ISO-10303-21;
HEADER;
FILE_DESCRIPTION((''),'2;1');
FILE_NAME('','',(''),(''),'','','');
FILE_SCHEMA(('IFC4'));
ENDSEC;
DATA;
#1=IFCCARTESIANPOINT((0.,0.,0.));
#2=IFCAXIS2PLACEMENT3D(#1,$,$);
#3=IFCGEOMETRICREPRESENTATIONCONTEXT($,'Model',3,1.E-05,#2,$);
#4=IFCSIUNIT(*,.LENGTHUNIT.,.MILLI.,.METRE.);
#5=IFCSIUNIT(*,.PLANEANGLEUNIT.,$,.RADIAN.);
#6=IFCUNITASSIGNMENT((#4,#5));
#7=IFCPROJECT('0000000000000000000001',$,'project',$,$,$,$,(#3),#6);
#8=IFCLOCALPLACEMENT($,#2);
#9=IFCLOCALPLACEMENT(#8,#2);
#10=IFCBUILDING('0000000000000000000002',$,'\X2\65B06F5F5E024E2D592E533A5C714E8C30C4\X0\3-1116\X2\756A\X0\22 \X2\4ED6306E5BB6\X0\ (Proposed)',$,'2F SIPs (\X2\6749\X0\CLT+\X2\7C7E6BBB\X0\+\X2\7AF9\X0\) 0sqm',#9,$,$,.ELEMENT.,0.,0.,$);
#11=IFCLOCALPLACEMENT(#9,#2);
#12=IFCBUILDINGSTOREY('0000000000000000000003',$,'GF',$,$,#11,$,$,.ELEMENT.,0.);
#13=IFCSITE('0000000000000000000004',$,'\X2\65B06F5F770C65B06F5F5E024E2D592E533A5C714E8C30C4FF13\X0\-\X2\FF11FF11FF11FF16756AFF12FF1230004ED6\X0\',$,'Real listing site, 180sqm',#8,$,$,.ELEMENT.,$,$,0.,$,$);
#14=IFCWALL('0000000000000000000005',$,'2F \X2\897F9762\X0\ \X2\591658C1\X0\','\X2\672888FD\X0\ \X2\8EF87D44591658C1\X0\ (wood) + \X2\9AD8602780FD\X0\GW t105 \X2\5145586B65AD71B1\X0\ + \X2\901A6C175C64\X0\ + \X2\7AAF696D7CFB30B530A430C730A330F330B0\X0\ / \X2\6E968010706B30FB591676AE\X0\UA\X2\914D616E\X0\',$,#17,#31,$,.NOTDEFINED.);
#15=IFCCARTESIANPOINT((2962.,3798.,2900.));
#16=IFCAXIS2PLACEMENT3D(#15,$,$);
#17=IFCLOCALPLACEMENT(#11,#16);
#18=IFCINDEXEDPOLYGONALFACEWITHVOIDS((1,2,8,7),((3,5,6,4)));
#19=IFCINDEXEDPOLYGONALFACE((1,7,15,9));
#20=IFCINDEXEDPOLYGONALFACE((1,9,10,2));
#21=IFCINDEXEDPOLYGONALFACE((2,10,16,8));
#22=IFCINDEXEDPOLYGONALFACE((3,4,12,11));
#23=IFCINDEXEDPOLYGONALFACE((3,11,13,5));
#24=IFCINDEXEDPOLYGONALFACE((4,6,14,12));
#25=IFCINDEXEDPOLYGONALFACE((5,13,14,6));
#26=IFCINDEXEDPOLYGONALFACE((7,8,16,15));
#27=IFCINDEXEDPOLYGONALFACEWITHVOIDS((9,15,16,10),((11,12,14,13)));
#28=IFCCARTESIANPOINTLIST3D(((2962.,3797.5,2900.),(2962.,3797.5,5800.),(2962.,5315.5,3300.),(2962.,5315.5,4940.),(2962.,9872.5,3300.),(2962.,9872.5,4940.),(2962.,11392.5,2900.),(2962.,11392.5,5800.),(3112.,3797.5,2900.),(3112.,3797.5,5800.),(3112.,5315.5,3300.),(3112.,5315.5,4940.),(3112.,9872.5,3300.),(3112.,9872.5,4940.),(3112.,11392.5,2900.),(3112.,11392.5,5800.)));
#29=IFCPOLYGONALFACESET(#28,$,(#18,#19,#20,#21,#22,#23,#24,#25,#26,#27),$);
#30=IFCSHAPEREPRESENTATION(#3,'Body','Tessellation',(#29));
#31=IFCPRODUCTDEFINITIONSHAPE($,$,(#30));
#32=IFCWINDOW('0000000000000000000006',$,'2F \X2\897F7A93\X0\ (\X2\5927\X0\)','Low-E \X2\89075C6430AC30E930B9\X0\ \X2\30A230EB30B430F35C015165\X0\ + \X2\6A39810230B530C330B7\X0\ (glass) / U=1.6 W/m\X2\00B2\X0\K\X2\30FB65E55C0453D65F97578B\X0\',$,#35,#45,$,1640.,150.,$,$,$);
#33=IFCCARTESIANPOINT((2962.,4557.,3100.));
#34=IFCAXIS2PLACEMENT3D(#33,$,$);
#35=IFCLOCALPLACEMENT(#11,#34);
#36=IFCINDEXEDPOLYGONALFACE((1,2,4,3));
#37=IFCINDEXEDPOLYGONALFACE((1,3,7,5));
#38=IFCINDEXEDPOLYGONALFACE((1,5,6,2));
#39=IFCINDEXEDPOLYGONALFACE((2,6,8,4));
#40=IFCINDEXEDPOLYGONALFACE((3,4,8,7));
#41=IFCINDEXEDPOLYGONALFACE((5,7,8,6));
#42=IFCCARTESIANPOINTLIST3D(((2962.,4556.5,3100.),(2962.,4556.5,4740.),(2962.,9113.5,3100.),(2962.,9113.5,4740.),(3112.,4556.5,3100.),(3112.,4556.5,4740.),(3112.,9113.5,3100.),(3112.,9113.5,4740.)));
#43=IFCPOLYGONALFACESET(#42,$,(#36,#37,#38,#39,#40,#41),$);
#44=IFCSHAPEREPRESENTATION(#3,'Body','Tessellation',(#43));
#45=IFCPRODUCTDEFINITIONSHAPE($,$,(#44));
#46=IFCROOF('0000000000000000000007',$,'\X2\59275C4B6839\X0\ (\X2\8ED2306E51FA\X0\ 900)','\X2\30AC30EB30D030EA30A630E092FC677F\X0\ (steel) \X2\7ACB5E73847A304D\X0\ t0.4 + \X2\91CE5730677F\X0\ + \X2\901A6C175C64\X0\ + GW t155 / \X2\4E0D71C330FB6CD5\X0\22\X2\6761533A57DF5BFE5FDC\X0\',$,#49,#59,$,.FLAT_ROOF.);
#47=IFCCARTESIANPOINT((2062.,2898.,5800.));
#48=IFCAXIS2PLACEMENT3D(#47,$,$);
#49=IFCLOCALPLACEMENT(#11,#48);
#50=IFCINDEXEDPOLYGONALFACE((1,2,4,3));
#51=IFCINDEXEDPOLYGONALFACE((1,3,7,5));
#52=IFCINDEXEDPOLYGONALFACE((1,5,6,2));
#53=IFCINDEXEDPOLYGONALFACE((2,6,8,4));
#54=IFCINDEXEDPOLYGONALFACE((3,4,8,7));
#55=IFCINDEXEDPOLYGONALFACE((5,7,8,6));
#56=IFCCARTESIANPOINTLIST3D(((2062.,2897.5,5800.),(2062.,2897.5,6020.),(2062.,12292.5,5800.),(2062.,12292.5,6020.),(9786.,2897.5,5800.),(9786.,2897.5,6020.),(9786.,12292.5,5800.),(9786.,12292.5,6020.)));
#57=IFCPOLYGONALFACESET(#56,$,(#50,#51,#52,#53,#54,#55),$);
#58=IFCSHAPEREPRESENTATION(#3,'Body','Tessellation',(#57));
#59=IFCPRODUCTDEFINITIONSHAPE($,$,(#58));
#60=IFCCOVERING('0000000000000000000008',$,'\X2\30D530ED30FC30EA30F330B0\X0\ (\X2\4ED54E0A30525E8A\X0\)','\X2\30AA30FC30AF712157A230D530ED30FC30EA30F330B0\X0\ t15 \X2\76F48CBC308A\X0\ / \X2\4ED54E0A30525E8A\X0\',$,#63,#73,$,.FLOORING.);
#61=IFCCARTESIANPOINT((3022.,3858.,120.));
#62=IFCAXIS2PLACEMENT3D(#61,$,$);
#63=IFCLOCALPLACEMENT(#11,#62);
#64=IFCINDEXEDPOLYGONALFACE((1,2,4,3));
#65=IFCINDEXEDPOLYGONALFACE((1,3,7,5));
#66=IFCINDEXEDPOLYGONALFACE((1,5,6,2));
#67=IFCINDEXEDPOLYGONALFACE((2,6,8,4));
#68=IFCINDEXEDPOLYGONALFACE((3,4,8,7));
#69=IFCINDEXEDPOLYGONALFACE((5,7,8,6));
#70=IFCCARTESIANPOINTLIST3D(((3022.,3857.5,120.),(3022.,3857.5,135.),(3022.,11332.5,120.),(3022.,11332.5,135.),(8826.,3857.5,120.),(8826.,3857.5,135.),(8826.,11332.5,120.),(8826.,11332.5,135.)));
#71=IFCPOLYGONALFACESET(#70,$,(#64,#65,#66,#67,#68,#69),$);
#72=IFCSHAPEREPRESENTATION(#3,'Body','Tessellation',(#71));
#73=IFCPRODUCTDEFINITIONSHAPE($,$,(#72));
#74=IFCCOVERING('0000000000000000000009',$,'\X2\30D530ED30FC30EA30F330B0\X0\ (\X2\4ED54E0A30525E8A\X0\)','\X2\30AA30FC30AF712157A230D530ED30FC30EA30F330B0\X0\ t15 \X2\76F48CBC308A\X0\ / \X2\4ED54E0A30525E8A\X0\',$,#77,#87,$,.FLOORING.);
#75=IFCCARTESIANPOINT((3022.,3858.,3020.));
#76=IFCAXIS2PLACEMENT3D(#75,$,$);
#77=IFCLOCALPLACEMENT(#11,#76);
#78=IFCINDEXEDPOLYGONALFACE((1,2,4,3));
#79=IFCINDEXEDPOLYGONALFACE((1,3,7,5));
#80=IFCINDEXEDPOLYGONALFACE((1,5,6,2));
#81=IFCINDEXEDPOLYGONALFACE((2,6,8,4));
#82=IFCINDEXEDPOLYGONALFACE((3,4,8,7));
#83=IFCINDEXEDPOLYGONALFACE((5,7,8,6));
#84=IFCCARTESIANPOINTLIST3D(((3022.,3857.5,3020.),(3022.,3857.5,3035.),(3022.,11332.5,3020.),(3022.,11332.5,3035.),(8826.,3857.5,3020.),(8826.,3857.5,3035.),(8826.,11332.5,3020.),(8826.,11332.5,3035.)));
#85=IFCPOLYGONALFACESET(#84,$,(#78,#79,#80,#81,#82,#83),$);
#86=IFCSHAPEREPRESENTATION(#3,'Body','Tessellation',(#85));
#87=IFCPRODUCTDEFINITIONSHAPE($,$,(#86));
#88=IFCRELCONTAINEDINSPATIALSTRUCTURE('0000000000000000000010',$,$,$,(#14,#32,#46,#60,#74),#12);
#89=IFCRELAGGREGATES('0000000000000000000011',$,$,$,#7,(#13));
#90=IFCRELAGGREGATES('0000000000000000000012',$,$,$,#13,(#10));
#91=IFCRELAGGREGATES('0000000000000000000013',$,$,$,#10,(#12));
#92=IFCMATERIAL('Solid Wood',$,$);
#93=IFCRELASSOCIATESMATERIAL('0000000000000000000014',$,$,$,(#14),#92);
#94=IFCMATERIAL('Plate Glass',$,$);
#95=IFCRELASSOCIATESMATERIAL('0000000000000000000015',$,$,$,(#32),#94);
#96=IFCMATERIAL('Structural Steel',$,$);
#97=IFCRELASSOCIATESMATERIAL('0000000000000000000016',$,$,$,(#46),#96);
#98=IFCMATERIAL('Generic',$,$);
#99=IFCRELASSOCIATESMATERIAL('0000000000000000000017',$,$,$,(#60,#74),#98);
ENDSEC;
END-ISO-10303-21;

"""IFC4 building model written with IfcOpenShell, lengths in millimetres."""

from ifc_helpers import new_model, si_unit, frame, frame_2d, origin, place, context, project, spatial, rectangle, extrude, material, element, fill, save


model = new_model("IFC4")

# Units and contexts
model_context = context("Model", 3, precision=1e-05, world=origin())
ifc_project = project(units=[si_unit("LENGTHUNIT", "METRE", prefix="MILLI"), si_unit("PLANEANGLEUNIT", "RADIAN")], contexts=[model_context])

# Site, building, storey
site_placement = place(None, origin())
site = spatial("IfcSite", under=ifc_project, at=site_placement, Name="新潟県新潟市中央区山二ツ３-１１１６番２２　他", ObjectType="Real listing site, 180sqm", CompositionType="ELEMENT", RefElevation=0.0)
building_placement = place(site_placement, origin())
building = spatial("IfcBuilding", under=site, at=building_placement, Name="新潟市中央区山二ツ3-1116番22 他の家 (Proposed)", ObjectType="2F SIPs (杉CLT+籾殻+竹) 0sqm", CompositionType="ELEMENT", ElevationOfRefHeight=0.0, ElevationOfTerrain=0.0)
storey_placement = place(building_placement, origin())
storey = spatial("IfcBuildingStorey", under=building, at=storey_placement, Name="GF", CompositionType="ELEMENT", Elevation=0.0)

# Shared definitions
ifc_material_1 = material(Name="Solid Wood")

# Shared definitions
ifc_material_2 = material(Name="Plate Glass")

# Wall, opening, window
wall_1_placement = place(storey_placement, frame((2962.0, 3798.0, 2900.0)))
wall_1 = element("IfcWall", 1, at=wall_1_placement, inside=storey, material=ifc_material_1, Name="2F 西面 外壁", Description="木製 軸組外壁 (wood) + 高性能GW t105 充填断熱 + 通気層 + 窯業系サイディング / 準耐火・外皮UA配慮", PredefinedType="NOTDEFINED", context=model_context, shape_type="SweptSolid", body=[
    extrude(rectangle(XDim=150.0, YDim=7595.0, at=frame_2d((75.0, 3797.0))), frame((2962.0, 3798.0, 2900.0)), (0.0, 0.0, 1.0), 2900.0),
])
opening_1_placement = place(storey_placement, frame((2962.0, 4557.0, 3100.0)))
opening_1 = element("IfcOpeningElement", 2, at=opening_1_placement, cuts=wall_1, PredefinedType="NOTDEFINED", context=model_context, shape_type="SweptSolid", body=[
    extrude(rectangle(XDim=150.0, YDim=4557.0, at=frame_2d((75.0, 2278.0))), frame((2962.0, 4557.0, 3100.0)), (0.0, 0.0, 1.0), 1640.0),
])
window_1_placement = place(storey_placement, frame((2962.0, 4557.0, 3100.0)))
window_1 = element("IfcWindow", 3, at=window_1_placement, inside=storey, material=ifc_material_2, Name="2F 西窓 (大)", Description="Low-E 複層ガラス アルゴン封入 + 樹脂サッシ (glass) / U=1.6 W/m²K・日射取得型", OverallHeight=1640.0, OverallWidth=150.0, context=model_context, shape_type="SweptSolid", body=[
    extrude(rectangle(XDim=150.0, YDim=4557.0, at=frame_2d((75.0, 2278.0))), frame((2962.0, 4557.0, 3100.0)), (0.0, 0.0, 1.0), 1640.0),
])
fill(opening_1, window_1)

# Roof
ifc_material_3 = material(Name="Structural Steel")
roof_placement = place(storey_placement, frame((2062.0, 2898.0, 5800.0)))
element("IfcRoof", 4, at=roof_placement, inside=storey, material=ifc_material_3, Name="大屋根 (軒の出 900)", Description="ガルバリウム鋼板 (steel) 立平葺き t0.4 + 野地板 + 通気層 + GW t155 / 不燃・法22条区域対応", PredefinedType="FLAT_ROOF", context=model_context, shape_type="SweptSolid", body=[
    extrude(rectangle(XDim=7724.0, YDim=9395.0, at=frame_2d((3862.0, 4697.0))), frame((2062.0, 2898.0, 5800.0)), (0.0, 0.0, 1.0), 220.0),
])

# Coverings
ifc_material_4 = material(Name="Generic")
covering_1_placement = place(storey_placement, frame((3022.0, 3858.0, 120.0)))
element("IfcCovering", 5, at=covering_1_placement, inside=storey, material=ifc_material_4, Name="フローリング (仕上げ床)", Description="オーク無垢フローリング t15 直貼り / 仕上げ床", PredefinedType="FLOORING", context=model_context, shape_type="SweptSolid", body=[
    extrude(rectangle(XDim=5804.0, YDim=7475.0, at=frame_2d((2902.0, 3737.0))), frame((3022.0, 3858.0, 120.0)), (0.0, 0.0, 1.0), 15.0),
])
covering_2_placement = place(storey_placement, frame((3022.0, 3858.0, 3020.0)))
element("IfcCovering", 6, at=covering_2_placement, inside=storey, material=ifc_material_4, Name="フローリング (仕上げ床)", Description="オーク無垢フローリング t15 直貼り / 仕上げ床", PredefinedType="FLOORING", context=model_context, shape_type="SweptSolid", body=[
    extrude(rectangle(XDim=5804.0, YDim=7475.0, at=frame_2d((2902.0, 3737.0))), frame((3022.0, 3858.0, 3020.0)), (0.0, 0.0, 1.0), 15.0),
])

save(model, "model.ifc")
